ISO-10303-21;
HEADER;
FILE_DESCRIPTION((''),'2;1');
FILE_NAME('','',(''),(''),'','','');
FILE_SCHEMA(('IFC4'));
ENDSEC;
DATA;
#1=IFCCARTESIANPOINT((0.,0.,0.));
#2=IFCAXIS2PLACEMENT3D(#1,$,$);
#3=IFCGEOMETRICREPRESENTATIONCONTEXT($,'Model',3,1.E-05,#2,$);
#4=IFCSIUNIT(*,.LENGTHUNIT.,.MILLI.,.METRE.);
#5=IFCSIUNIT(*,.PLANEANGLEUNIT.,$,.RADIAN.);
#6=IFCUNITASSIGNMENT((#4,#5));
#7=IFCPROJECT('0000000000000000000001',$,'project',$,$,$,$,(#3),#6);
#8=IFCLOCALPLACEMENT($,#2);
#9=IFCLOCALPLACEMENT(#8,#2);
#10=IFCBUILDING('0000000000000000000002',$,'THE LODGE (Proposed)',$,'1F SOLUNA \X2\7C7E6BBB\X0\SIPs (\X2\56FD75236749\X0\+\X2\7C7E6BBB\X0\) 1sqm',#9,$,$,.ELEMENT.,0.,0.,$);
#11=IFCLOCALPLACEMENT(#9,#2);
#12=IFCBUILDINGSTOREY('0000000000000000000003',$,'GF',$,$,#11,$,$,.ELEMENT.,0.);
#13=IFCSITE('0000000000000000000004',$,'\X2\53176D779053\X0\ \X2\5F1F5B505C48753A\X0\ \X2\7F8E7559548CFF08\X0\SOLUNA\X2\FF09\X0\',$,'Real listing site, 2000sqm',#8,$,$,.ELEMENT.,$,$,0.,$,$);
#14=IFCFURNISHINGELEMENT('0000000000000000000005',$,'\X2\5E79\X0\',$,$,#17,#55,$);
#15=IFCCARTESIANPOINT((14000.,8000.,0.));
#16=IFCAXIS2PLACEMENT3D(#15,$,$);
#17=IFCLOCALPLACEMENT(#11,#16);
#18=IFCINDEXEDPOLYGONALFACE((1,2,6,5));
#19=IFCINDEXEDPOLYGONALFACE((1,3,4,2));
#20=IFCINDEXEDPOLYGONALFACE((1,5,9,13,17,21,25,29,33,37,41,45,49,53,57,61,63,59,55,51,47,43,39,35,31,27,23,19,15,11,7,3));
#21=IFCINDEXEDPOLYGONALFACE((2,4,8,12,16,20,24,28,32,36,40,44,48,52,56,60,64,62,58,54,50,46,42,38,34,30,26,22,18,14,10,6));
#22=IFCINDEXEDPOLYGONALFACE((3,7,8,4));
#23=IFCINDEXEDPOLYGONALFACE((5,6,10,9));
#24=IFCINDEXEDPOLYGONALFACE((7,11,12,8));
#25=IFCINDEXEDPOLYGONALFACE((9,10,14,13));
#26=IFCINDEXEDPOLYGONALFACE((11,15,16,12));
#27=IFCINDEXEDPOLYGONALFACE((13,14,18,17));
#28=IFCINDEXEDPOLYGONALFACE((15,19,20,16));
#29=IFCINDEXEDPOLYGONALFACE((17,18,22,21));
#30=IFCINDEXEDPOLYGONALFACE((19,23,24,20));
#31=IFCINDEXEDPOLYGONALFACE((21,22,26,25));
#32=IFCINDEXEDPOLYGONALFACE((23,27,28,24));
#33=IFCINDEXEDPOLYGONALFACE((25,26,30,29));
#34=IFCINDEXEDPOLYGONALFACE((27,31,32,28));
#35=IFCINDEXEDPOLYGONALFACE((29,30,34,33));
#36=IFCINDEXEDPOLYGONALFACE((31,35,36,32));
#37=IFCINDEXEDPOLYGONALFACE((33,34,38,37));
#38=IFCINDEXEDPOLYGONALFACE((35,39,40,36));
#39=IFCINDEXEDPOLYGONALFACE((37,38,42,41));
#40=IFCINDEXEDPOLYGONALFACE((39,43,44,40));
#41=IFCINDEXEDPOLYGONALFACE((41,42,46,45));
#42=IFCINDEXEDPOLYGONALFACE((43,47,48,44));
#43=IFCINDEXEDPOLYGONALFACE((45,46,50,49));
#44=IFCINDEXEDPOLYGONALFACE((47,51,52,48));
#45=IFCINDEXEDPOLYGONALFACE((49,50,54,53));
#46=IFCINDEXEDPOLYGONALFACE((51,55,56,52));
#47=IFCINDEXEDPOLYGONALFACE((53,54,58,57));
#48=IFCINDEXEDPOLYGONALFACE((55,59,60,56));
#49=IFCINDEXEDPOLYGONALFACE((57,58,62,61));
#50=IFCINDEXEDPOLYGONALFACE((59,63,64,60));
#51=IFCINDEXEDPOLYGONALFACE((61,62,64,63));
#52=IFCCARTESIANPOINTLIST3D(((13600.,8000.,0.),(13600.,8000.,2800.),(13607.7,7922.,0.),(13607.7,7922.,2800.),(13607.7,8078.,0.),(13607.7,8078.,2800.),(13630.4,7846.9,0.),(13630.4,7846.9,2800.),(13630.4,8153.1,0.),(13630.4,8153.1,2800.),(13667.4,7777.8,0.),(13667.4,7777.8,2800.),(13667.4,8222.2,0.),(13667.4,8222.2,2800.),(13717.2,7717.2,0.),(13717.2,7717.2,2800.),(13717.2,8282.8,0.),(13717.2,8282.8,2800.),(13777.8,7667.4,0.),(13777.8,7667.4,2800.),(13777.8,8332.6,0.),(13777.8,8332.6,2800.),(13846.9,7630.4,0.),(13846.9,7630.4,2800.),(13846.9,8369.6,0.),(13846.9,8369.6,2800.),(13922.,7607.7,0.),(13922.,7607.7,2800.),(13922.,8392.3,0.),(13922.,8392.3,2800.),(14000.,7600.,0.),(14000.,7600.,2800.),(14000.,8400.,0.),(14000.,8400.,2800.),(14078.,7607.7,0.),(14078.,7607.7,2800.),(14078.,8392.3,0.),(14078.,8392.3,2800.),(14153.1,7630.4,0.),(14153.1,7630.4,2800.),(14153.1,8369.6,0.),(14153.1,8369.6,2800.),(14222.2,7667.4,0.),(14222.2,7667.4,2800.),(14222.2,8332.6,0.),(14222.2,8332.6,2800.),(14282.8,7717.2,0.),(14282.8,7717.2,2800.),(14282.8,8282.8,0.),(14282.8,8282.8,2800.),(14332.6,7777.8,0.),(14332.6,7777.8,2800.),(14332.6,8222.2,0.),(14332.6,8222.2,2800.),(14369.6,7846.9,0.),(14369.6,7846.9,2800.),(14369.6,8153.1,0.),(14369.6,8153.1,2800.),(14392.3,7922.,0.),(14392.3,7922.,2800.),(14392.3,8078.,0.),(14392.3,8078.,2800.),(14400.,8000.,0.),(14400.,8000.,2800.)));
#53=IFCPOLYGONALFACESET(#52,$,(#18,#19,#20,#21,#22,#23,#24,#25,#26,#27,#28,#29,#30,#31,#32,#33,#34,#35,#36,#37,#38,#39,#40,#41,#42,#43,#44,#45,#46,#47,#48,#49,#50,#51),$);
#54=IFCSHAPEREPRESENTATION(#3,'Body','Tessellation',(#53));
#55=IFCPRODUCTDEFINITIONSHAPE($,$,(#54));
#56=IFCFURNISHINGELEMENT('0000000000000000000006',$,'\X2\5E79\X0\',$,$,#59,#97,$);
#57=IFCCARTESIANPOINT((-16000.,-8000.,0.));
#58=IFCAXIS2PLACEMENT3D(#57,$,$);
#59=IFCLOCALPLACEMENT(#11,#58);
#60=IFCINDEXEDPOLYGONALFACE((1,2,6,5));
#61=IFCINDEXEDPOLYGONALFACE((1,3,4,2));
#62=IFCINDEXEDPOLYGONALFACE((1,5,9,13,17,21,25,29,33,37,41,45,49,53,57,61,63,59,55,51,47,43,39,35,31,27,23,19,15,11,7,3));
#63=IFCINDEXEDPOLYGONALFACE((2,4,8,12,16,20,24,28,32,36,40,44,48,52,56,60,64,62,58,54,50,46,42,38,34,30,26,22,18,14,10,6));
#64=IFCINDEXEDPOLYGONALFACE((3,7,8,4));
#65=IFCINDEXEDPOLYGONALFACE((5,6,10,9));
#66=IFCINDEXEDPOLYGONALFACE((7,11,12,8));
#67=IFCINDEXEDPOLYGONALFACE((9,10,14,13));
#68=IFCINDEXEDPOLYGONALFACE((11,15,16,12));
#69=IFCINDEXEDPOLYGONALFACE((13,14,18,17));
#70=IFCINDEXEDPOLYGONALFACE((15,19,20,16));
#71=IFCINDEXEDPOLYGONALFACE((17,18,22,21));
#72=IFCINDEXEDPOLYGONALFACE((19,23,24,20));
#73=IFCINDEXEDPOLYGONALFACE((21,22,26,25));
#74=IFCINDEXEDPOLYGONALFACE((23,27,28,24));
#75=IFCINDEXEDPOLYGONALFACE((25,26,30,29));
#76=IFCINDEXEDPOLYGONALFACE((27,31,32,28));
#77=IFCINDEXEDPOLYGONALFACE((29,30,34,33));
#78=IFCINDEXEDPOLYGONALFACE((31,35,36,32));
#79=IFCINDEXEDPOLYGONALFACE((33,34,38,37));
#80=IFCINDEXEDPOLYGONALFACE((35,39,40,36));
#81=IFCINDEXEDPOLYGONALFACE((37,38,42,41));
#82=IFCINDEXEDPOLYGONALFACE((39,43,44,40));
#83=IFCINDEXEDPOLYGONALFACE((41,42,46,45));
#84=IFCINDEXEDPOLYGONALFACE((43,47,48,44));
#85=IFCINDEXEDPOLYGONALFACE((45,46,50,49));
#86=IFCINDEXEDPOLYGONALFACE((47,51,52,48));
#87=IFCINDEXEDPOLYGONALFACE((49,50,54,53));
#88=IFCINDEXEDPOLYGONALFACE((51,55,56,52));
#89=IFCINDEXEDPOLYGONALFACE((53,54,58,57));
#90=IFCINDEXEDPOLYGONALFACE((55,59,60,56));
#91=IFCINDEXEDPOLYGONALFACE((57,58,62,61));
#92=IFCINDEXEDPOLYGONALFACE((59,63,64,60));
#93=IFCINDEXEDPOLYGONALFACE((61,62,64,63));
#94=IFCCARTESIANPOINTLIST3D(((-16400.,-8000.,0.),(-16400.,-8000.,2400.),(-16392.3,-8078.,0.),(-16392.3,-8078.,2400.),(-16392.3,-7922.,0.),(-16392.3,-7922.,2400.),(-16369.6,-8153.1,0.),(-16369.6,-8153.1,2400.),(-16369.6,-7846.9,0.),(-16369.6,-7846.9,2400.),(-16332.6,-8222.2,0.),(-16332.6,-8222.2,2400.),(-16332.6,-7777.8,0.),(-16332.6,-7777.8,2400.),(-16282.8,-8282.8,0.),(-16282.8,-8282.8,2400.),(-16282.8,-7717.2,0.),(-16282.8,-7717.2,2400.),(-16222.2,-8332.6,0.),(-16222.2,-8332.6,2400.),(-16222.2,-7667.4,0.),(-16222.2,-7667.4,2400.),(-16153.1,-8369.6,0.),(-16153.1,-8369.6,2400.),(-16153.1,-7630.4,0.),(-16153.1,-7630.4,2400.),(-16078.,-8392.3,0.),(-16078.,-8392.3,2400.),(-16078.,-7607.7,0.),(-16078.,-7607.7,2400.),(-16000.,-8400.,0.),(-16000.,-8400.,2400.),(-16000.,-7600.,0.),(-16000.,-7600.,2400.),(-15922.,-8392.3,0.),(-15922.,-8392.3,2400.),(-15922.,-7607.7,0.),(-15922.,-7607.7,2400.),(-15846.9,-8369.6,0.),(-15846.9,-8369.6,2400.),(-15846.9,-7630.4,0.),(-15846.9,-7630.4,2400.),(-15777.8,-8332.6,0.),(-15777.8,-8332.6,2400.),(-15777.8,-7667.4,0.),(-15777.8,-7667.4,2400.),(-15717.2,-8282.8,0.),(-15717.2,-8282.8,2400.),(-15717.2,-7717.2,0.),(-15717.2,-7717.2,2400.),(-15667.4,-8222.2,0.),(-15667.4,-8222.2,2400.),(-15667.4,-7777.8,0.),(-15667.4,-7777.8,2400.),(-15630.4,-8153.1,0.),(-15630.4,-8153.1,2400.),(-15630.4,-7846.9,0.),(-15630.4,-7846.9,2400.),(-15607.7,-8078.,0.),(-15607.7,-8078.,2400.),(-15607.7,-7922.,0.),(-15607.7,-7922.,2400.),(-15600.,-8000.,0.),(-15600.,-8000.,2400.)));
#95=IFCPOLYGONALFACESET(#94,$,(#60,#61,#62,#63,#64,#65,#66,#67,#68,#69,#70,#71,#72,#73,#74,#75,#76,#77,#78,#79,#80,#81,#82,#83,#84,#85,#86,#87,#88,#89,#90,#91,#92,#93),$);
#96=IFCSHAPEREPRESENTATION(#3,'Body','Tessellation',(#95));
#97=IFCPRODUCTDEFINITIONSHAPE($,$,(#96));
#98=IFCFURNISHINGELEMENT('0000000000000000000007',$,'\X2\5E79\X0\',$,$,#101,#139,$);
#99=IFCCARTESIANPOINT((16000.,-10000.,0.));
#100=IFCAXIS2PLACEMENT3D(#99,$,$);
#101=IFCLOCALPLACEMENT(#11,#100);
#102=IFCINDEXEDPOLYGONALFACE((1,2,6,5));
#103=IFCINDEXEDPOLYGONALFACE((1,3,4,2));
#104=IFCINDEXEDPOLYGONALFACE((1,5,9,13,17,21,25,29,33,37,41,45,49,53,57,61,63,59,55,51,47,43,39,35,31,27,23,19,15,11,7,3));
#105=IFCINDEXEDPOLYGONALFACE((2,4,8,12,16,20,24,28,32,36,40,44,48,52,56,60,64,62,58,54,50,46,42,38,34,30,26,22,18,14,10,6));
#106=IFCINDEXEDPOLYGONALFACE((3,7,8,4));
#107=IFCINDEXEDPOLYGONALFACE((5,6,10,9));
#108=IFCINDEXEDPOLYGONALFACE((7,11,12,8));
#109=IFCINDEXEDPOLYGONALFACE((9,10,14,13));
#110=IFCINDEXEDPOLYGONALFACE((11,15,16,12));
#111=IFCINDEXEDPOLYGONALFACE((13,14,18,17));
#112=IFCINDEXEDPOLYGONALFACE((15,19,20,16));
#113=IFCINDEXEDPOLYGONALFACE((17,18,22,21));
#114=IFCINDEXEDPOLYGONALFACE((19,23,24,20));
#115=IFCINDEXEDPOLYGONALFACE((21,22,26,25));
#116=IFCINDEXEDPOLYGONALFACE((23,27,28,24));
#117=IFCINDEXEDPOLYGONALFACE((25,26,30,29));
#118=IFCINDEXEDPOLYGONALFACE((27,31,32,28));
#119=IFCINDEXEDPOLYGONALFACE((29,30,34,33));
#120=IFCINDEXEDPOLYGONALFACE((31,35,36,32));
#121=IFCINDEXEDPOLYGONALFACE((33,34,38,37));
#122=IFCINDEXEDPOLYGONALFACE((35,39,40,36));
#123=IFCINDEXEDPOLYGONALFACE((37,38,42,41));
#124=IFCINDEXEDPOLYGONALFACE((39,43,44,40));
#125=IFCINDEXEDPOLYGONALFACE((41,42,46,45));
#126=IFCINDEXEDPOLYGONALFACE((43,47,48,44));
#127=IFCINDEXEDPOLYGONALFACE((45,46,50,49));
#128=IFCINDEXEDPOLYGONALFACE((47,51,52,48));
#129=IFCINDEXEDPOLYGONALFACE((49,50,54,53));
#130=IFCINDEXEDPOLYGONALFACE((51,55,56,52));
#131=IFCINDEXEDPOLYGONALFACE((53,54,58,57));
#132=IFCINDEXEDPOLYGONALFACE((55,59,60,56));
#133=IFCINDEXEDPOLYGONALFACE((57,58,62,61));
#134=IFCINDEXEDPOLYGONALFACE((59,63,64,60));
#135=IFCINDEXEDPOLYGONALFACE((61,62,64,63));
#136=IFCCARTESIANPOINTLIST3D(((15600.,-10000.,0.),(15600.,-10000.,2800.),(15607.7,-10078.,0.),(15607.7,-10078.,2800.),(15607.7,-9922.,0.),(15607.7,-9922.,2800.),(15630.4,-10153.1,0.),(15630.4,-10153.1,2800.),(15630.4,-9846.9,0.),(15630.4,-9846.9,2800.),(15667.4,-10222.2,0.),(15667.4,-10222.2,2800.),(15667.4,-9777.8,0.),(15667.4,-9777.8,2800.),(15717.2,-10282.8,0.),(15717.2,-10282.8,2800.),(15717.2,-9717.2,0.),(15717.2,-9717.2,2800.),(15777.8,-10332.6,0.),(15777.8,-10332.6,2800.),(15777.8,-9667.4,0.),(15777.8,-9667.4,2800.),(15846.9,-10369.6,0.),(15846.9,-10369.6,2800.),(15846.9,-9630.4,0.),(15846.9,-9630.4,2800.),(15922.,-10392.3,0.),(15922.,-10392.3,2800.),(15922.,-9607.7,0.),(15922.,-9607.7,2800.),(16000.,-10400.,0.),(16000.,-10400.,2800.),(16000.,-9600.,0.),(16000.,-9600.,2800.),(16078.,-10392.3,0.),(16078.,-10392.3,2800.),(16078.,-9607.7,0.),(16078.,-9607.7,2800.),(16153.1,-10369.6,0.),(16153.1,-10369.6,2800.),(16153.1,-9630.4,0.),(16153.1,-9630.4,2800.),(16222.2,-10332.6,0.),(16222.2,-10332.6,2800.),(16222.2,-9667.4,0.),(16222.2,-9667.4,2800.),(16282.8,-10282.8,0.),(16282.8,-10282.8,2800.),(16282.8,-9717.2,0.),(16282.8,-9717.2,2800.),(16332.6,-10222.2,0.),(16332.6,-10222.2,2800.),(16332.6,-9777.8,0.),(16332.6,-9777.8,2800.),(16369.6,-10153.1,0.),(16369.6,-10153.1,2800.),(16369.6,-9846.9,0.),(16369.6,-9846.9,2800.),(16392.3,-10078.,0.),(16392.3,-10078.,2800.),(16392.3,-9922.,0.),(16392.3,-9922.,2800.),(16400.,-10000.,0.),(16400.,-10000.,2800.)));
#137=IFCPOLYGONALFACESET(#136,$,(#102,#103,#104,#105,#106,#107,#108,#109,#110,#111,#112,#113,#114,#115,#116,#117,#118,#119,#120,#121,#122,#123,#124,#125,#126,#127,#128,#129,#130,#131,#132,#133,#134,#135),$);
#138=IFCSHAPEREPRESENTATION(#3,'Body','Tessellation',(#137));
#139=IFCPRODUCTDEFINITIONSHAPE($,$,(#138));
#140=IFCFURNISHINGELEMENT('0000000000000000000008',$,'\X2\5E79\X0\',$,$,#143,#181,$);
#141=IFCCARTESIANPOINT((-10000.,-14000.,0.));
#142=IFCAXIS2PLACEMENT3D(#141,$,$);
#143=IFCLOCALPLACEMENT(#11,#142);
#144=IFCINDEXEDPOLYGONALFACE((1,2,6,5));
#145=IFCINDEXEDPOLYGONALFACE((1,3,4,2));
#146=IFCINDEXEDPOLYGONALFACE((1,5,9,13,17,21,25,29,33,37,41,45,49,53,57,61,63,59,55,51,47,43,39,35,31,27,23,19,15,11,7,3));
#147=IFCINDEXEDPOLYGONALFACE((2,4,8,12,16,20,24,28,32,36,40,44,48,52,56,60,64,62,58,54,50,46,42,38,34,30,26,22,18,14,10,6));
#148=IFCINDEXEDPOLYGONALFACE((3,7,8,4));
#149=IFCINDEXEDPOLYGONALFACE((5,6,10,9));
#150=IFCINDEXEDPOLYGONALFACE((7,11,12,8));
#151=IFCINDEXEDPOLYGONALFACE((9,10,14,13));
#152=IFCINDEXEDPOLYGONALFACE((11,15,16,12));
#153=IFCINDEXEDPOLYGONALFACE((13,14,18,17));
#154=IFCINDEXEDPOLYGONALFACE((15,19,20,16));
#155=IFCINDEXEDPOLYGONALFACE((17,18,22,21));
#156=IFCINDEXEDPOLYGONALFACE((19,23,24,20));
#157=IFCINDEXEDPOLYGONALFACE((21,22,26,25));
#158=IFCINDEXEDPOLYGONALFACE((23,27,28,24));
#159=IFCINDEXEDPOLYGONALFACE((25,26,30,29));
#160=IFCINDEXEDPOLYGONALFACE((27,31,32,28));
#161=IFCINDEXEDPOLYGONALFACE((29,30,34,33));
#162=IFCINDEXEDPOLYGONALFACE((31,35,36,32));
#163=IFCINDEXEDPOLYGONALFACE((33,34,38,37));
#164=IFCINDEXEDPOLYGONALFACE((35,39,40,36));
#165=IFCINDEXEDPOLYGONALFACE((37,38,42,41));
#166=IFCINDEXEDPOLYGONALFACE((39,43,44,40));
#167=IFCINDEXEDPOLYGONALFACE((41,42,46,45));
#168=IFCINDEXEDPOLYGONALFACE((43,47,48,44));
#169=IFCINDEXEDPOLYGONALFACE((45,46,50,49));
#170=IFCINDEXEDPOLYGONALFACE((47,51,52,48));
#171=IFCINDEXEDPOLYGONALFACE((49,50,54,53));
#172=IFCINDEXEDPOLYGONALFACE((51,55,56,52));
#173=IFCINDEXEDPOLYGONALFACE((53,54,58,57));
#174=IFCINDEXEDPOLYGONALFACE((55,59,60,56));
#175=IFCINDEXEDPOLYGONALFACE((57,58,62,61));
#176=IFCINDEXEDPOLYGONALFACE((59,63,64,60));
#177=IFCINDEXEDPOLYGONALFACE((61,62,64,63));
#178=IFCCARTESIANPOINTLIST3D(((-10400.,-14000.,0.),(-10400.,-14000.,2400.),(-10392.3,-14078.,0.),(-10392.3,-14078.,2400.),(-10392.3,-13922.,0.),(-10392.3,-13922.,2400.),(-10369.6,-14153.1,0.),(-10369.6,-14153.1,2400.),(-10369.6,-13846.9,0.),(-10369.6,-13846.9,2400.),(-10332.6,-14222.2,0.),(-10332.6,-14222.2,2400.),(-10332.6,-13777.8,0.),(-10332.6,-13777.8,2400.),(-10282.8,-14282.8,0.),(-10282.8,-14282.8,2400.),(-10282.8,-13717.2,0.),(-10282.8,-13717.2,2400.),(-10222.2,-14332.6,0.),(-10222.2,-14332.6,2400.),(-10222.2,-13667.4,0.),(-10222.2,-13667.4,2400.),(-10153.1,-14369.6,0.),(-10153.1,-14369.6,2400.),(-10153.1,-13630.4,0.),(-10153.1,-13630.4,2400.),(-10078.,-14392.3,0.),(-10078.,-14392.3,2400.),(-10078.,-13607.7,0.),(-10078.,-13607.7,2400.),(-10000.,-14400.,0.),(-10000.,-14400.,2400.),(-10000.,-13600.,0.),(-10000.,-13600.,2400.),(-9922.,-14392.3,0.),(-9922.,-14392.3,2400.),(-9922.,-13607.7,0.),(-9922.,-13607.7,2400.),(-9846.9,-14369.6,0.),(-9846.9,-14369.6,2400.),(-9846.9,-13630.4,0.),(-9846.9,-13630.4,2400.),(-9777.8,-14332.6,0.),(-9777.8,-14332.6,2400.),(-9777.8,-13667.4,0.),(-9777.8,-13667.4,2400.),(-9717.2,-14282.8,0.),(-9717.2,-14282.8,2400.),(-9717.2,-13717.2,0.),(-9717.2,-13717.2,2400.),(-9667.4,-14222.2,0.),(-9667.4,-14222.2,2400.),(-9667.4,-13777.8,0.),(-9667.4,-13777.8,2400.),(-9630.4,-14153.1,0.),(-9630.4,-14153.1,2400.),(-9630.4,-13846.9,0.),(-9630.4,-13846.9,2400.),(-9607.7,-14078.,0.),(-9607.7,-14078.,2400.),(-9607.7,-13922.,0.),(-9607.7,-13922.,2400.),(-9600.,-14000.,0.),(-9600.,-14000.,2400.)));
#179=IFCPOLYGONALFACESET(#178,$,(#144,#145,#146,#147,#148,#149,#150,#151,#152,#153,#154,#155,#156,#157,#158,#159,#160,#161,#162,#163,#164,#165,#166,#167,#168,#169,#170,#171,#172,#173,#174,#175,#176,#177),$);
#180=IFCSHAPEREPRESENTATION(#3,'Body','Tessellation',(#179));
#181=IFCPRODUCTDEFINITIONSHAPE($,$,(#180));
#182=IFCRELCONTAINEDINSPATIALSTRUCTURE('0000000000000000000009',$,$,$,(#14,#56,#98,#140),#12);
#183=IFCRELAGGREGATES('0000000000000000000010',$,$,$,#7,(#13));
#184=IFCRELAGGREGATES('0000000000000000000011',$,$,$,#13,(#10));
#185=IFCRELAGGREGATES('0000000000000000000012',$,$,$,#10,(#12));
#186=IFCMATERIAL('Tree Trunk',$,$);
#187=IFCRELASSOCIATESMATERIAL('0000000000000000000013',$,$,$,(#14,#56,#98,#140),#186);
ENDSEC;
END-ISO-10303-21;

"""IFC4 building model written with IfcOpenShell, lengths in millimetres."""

from ifc_helpers import new_model, si_unit, frame, origin, origin_2d, place, context, project, spatial, circle, extrude, material, element, save


model = new_model("IFC4")

# Units and contexts
model_context = context("Model", 3, precision=1e-05, world=origin())
ifc_project = project(units=[si_unit("LENGTHUNIT", "METRE", prefix="MILLI"), si_unit("PLANEANGLEUNIT", "RADIAN")], contexts=[model_context])

# Site, building, storey
site_placement = place(None, origin())
site = spatial("IfcSite", under=ifc_project, at=site_placement, Name="北海道 弟子屈町 美留和（SOLUNA）", ObjectType="Real listing site, 2000sqm", CompositionType="ELEMENT", RefElevation=0.0)
building_placement = place(site_placement, origin())
building = spatial("IfcBuilding", under=site, at=building_placement, Name="THE LODGE (Proposed)", ObjectType="1F SOLUNA 籾殻SIPs (国産杉+籾殻) 1sqm", CompositionType="ELEMENT", ElevationOfRefHeight=0.0, ElevationOfTerrain=0.0)
storey_placement = place(building_placement, origin())
storey = spatial("IfcBuildingStorey", under=building, at=storey_placement, Name="GF", CompositionType="ELEMENT", Elevation=0.0)

# Furnishing elements
ifc_material_1 = material(Name="Tree Trunk")
furnishing_1_placement = place(storey_placement, frame((14000.0, 8000.0, 0.0)))
element("IfcFurnishingElement", 1, at=furnishing_1_placement, inside=storey, material=ifc_material_1, Name="幹", context=model_context, shape_type="SweptSolid", body=[
    extrude(circle(Radius=400.0, at=origin_2d()), frame((14000.0, 8000.0, 0.0)), (0.0, 0.0, 1.0), 2800.0),
])
furnishing_2_placement = place(storey_placement, frame((-16000.0, -8000.0, 0.0)))
element("IfcFurnishingElement", 2, at=furnishing_2_placement, inside=storey, material=ifc_material_1, Name="幹", context=model_context, shape_type="SweptSolid", body=[
    extrude(circle(Radius=400.0, at=origin_2d()), frame((-16000.0, -8000.0, 0.0)), (0.0, 0.0, 1.0), 2400.0),
])
furnishing_3_placement = place(storey_placement, frame((16000.0, -10000.0, 0.0)))
element("IfcFurnishingElement", 3, at=furnishing_3_placement, inside=storey, material=ifc_material_1, Name="幹", context=model_context, shape_type="SweptSolid", body=[
    extrude(circle(Radius=400.0, at=origin_2d()), frame((16000.0, -10000.0, 0.0)), (0.0, 0.0, 1.0), 2800.0),
])
furnishing_4_placement = place(storey_placement, frame((-10000.0, -14000.0, 0.0)))
element("IfcFurnishingElement", 4, at=furnishing_4_placement, inside=storey, material=ifc_material_1, Name="幹", context=model_context, shape_type="SweptSolid", body=[
    extrude(circle(Radius=400.0, at=origin_2d()), frame((-10000.0, -14000.0, 0.0)), (0.0, 0.0, 1.0), 2400.0),
])

save(model, "model.ifc")
